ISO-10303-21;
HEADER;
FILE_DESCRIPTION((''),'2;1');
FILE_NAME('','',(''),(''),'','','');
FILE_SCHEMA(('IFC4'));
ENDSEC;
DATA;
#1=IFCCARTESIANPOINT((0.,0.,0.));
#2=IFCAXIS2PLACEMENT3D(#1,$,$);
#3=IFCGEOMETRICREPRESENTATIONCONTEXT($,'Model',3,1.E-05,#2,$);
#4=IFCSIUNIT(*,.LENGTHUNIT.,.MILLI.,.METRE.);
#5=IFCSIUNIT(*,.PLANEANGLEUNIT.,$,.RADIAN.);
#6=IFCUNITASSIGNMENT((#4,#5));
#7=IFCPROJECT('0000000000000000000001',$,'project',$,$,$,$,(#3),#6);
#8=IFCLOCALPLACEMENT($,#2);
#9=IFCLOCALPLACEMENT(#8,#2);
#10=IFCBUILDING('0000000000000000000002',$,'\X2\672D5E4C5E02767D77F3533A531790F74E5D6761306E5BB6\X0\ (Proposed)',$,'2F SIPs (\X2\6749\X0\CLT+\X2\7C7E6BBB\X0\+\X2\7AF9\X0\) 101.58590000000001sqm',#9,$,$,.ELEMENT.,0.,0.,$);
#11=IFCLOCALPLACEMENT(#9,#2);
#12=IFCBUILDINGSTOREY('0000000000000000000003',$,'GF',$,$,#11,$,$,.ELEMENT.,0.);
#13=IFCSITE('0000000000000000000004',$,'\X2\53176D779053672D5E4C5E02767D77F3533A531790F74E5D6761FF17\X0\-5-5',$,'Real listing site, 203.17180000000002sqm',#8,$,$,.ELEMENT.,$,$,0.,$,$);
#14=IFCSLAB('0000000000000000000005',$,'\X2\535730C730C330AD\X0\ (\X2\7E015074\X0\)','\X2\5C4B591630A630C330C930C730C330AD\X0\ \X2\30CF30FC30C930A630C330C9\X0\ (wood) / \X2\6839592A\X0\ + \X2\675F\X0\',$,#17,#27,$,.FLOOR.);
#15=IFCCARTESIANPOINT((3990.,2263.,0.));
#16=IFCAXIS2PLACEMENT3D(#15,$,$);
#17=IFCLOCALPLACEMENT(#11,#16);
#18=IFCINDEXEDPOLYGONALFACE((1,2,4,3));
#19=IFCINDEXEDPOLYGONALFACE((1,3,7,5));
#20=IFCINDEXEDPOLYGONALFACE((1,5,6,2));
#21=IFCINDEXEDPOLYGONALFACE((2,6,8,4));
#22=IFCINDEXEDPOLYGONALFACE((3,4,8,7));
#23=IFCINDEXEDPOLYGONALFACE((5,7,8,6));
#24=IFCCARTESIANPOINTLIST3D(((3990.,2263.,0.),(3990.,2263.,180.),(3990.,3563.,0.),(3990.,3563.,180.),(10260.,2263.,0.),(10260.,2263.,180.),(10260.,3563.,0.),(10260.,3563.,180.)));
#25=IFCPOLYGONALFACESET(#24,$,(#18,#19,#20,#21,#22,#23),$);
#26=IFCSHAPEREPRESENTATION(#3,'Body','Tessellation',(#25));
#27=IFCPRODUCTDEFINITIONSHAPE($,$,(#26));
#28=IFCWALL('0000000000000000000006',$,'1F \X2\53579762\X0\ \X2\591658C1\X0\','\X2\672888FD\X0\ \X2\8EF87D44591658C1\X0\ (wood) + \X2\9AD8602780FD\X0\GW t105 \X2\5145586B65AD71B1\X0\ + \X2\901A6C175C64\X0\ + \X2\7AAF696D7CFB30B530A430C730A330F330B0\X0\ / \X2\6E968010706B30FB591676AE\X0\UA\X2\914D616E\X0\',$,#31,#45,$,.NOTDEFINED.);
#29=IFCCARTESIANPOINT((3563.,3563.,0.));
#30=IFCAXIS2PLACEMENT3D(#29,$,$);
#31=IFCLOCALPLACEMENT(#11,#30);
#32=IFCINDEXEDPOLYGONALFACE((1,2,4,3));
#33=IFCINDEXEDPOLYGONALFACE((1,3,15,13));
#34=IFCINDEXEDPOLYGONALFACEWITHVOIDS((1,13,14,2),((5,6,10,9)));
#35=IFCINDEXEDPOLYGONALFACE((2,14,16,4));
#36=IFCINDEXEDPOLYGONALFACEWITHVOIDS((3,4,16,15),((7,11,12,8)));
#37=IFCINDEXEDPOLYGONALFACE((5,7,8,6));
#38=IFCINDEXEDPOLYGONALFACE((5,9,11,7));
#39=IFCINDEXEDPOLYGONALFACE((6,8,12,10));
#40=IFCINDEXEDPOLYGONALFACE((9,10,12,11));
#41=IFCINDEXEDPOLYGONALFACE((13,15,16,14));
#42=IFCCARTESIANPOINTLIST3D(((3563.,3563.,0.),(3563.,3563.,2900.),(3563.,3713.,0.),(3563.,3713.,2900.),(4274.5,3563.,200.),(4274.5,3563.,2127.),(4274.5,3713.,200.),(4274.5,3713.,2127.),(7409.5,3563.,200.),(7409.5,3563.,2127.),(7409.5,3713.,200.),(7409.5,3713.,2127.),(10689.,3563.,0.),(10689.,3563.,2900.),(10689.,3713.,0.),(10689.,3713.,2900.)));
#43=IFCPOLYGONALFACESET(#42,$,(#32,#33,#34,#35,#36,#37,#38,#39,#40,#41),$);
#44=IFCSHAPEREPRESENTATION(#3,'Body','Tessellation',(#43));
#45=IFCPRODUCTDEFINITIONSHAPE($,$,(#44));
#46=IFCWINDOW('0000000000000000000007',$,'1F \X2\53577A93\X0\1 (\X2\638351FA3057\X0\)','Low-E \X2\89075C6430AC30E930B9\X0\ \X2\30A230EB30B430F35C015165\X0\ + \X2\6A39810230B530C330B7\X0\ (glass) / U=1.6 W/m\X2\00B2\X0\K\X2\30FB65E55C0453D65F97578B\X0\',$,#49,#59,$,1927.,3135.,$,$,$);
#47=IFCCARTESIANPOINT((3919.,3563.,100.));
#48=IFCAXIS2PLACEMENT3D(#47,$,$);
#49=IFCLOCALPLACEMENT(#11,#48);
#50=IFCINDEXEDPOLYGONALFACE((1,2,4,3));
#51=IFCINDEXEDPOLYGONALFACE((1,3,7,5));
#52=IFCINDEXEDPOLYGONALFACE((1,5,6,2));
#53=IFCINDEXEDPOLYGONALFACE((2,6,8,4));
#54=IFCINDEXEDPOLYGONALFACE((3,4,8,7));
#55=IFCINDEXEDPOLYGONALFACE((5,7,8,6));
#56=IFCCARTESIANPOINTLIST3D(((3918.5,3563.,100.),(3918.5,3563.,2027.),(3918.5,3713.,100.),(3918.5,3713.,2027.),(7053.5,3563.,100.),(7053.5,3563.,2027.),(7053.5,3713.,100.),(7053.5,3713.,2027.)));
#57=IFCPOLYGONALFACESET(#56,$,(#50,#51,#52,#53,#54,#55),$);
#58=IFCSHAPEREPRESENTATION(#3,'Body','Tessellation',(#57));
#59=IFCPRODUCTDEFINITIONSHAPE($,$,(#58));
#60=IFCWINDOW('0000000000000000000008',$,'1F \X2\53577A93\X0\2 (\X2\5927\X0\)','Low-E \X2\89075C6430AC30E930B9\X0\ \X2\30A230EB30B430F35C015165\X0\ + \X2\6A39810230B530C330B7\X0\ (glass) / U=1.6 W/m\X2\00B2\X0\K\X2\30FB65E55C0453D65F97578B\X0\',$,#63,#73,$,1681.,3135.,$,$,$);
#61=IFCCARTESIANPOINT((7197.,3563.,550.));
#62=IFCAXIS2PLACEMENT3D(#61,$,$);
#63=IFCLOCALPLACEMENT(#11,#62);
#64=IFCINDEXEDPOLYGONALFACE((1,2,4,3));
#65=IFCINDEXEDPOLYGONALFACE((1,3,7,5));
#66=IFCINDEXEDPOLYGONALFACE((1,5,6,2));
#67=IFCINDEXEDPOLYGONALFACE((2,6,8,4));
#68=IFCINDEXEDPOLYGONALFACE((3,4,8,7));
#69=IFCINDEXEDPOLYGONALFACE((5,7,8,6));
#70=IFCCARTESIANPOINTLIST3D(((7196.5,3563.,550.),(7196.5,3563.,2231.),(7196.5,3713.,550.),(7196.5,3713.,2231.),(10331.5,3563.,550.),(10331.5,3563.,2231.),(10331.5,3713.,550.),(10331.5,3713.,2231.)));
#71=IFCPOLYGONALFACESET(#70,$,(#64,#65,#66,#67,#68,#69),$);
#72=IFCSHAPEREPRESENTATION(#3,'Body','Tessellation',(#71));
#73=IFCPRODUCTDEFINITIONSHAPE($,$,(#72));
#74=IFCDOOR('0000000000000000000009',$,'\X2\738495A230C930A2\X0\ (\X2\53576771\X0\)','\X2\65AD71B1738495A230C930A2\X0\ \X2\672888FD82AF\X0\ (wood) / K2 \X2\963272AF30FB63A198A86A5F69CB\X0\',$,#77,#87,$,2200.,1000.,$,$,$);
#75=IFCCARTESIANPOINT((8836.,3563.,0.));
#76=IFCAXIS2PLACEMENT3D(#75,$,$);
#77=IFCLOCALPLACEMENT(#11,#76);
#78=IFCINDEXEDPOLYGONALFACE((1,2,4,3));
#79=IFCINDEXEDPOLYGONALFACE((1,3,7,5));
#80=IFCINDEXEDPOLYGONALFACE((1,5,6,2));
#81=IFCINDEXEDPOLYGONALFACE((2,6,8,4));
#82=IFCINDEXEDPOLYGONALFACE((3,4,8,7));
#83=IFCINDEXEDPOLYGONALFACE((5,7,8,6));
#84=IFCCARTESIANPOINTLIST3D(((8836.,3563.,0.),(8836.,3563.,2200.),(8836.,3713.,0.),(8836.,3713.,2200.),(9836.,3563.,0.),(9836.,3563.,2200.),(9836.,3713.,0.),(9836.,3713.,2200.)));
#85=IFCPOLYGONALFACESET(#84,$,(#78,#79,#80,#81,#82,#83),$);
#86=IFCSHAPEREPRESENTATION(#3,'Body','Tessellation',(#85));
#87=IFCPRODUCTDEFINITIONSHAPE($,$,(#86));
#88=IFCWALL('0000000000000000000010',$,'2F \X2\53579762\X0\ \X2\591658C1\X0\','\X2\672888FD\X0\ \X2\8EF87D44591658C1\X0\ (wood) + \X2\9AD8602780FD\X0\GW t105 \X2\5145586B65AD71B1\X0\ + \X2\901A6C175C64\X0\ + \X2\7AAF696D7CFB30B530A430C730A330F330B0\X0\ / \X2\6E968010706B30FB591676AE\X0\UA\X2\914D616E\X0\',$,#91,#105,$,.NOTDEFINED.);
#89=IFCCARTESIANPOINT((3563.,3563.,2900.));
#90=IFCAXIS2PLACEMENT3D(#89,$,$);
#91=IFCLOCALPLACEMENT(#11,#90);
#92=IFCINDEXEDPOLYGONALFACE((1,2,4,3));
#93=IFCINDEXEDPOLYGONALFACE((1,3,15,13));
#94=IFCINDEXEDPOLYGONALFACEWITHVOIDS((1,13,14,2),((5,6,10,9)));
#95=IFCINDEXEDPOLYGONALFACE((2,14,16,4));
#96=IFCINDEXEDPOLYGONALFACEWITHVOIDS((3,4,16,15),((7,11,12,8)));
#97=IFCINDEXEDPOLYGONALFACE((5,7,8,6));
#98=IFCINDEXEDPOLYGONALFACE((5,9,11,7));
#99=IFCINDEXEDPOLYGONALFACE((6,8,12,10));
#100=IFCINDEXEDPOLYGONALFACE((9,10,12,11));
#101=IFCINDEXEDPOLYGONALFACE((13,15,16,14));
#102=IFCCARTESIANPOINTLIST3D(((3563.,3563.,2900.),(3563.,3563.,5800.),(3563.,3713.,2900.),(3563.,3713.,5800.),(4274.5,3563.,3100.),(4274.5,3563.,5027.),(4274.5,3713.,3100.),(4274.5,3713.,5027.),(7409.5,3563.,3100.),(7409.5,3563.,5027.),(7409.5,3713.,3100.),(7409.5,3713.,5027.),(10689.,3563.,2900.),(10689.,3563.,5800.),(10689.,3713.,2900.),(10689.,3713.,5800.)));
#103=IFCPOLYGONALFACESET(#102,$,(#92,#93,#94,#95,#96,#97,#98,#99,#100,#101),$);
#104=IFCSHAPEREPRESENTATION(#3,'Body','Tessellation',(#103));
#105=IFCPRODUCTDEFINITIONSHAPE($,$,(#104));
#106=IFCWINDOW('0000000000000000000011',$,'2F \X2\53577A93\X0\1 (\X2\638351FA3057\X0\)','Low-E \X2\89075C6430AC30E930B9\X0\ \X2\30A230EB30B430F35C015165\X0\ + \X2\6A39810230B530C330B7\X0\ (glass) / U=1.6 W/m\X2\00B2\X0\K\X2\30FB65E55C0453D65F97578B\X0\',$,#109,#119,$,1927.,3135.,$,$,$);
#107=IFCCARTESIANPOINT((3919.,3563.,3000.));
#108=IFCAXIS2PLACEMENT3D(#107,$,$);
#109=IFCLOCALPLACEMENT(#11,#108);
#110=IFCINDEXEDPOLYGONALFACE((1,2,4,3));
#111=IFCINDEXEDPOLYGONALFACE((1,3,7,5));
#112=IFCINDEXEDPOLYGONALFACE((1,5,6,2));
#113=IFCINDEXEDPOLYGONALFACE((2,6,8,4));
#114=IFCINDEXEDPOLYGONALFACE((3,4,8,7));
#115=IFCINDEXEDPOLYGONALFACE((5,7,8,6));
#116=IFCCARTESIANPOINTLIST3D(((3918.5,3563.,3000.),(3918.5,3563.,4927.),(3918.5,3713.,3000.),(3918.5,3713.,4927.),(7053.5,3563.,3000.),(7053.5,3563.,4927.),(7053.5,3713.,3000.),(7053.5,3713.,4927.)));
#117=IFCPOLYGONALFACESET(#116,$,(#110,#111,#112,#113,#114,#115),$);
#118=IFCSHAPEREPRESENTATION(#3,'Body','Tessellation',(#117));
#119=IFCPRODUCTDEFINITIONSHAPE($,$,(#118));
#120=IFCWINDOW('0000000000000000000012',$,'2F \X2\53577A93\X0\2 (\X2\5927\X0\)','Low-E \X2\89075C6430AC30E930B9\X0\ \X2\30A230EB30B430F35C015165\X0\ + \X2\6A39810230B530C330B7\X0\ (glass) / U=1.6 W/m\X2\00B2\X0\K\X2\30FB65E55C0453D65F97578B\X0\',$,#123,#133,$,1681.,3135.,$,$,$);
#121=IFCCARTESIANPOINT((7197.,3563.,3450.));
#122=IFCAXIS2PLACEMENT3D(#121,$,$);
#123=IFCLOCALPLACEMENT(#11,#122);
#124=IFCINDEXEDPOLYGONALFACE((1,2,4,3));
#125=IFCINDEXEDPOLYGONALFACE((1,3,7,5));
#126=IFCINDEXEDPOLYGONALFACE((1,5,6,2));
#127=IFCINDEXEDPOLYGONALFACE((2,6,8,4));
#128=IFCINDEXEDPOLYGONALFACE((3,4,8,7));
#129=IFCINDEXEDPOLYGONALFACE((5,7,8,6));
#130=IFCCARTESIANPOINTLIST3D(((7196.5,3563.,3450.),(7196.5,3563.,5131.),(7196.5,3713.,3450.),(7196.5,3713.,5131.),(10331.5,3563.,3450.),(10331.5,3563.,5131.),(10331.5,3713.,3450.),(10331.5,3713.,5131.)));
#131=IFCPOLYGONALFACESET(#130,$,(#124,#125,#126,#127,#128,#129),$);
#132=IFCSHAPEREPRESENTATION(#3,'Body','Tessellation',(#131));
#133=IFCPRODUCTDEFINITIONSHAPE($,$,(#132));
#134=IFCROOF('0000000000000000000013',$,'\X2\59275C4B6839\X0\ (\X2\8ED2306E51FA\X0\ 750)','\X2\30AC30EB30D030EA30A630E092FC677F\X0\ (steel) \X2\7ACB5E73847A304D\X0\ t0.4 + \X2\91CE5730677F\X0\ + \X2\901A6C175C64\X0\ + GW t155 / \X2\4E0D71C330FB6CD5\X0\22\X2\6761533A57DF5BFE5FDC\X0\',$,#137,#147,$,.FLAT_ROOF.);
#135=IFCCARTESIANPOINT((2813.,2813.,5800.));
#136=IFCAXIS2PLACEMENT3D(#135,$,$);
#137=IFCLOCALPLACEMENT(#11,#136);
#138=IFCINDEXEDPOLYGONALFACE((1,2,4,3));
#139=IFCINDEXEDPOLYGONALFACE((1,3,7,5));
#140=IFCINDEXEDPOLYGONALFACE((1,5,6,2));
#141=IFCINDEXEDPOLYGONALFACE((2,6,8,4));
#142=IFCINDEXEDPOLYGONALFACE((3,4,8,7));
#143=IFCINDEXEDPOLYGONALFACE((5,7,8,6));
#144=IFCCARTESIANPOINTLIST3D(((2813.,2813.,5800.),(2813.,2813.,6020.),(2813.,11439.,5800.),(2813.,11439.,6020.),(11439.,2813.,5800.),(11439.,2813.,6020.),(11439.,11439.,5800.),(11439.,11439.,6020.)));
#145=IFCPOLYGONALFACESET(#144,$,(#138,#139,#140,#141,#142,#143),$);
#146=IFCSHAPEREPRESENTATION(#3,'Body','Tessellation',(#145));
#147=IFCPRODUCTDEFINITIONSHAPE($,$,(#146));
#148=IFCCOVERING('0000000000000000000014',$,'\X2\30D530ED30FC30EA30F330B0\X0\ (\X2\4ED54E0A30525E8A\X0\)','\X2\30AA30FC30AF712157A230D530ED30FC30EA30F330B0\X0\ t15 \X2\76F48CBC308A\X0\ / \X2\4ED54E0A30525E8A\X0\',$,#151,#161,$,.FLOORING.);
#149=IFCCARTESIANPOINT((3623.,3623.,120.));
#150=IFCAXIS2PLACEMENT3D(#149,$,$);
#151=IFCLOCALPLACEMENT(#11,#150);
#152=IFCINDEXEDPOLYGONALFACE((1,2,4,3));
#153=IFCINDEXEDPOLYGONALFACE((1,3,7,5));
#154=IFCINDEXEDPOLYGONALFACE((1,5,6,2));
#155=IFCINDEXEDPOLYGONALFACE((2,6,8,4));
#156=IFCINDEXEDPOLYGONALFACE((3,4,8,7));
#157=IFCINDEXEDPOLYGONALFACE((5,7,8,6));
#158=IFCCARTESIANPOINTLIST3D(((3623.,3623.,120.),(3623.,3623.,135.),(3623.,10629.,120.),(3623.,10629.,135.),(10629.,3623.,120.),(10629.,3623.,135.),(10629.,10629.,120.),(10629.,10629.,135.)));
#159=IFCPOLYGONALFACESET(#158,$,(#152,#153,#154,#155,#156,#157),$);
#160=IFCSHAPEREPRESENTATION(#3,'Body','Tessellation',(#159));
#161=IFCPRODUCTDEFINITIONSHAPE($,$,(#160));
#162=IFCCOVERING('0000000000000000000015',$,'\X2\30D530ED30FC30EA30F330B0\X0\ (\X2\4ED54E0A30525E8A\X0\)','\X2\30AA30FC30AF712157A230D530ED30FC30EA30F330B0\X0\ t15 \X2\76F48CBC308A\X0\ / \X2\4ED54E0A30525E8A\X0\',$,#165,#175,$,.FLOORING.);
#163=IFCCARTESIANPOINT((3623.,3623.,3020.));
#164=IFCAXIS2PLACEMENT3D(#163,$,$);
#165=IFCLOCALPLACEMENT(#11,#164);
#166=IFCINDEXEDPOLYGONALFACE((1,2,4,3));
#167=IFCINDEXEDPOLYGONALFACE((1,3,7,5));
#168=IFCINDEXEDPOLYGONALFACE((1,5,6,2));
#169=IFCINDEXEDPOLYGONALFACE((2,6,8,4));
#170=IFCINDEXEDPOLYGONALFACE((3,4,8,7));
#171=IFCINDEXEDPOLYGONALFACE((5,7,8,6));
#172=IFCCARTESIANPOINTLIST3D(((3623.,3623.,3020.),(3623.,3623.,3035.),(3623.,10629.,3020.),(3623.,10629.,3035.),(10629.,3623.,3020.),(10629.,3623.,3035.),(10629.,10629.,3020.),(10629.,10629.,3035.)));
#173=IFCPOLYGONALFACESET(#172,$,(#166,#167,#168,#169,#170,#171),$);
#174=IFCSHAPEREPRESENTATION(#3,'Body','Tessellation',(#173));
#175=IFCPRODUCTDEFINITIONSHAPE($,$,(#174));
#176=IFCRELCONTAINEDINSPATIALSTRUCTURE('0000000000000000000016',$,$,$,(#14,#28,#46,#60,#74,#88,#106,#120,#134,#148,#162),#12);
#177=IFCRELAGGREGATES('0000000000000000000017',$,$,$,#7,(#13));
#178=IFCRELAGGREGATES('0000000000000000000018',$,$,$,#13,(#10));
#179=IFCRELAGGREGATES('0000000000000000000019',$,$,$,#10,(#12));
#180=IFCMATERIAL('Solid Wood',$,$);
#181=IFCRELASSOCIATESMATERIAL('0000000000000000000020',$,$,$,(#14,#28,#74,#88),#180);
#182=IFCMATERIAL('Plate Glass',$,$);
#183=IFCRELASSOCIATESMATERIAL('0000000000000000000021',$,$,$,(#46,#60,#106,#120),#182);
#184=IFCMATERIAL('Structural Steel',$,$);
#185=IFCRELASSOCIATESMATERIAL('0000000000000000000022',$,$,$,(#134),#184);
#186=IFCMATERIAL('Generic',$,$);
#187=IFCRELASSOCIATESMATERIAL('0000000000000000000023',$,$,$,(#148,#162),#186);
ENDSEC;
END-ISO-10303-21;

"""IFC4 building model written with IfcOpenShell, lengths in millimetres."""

from ifc_helpers import new_model, si_unit, frame, frame_2d, origin, place, context, project, spatial, rectangle, extrude, material, element, fill, save


model = new_model("IFC4")

# Units and contexts
model_context = context("Model", 3, precision=1e-05, world=origin())
ifc_project = project(units=[si_unit("LENGTHUNIT", "METRE", prefix="MILLI"), si_unit("PLANEANGLEUNIT", "RADIAN")], contexts=[model_context])

# Site, building, storey
site_placement = place(None, origin())
site = spatial("IfcSite", under=ifc_project, at=site_placement, Name="北海道札幌市白石区北郷九条７-5-5", ObjectType="Real listing site, 203.17180000000002sqm", CompositionType="ELEMENT", RefElevation=0.0)
building_placement = place(site_placement, origin())
building = spatial("IfcBuilding", under=site, at=building_placement, Name="札幌市白石区北郷九条の家 (Proposed)", ObjectType="2F SIPs (杉CLT+籾殻+竹) 101.58590000000001sqm", CompositionType="ELEMENT", ElevationOfRefHeight=0.0, ElevationOfTerrain=0.0)
storey_placement = place(building_placement, origin())
storey = spatial("IfcBuildingStorey", under=building, at=storey_placement, Name="GF", CompositionType="ELEMENT", Elevation=0.0)

# Slab
ifc_material_1 = material(Name="Solid Wood")
slab_1_placement = place(storey_placement, frame((3990.0, 2263.0, 0.0)))
element("IfcSlab", 1, at=slab_1_placement, inside=storey, material=ifc_material_1, Name="南デッキ (縁側)", Description="屋外ウッドデッキ ハードウッド (wood) / 根太 + 束", PredefinedType="FLOOR", context=model_context, shape_type="SweptSolid", body=[
    extrude(rectangle(XDim=6270.0, YDim=1300.0, at=frame_2d((3135.0, 650.0))), frame((3990.0, 2263.0, 0.0)), (0.0, 0.0, 1.0), 180.0),
])

# Wall, openings, windows, door
wall_1_placement = place(storey_placement, frame((3563.0, 3563.0, 0.0)))
wall_1 = element("IfcWall", 2, at=wall_1_placement, inside=storey, material=ifc_material_1, Name="1F 南面 外壁", Description="木製 軸組外壁 (wood) + 高性能GW t105 充填断熱 + 通気層 + 窯業系サイディング / 準耐火・外皮UA配慮", PredefinedType="NOTDEFINED", context=model_context, shape_type="SweptSolid", body=[
    extrude(rectangle(XDim=7126.0, YDim=150.0, at=frame_2d((3563.0, 75.0))), frame((3563.0, 3563.0, 0.0)), (0.0, 0.0, 1.0), 2900.0),
])
opening_1_placement = place(storey_placement, frame((3919.0, 3563.0, 100.0)))
opening_1 = element("IfcOpeningElement", 3, at=opening_1_placement, cuts=wall_1, PredefinedType="NOTDEFINED", context=model_context, shape_type="SweptSolid", body=[
    extrude(rectangle(XDim=3135.0, YDim=150.0, at=frame_2d((1567.0, 75.0))), frame((3919.0, 3563.0, 100.0)), (0.0, 0.0, 1.0), 1927.0),
])
opening_2_placement = place(storey_placement, frame((7197.0, 3563.0, 550.0)))
opening_2 = element("IfcOpeningElement", 4, at=opening_2_placement, cuts=wall_1, PredefinedType="NOTDEFINED", context=model_context, shape_type="SweptSolid", body=[
    extrude(rectangle(XDim=3135.0, YDim=150.0, at=frame_2d((1567.0, 75.0))), frame((7197.0, 3563.0, 550.0)), (0.0, 0.0, 1.0), 1681.0),
])
opening_3_placement = place(storey_placement, frame((8836.0, 3563.0, 0.0)))
opening_3 = element("IfcOpeningElement", 5, at=opening_3_placement, cuts=wall_1, PredefinedType="NOTDEFINED", context=model_context, shape_type="SweptSolid", body=[
    extrude(rectangle(XDim=1000.0, YDim=150.0, at=frame_2d((500.0, 75.0))), frame((8836.0, 3563.0, 0.0)), (0.0, 0.0, 1.0), 2200.0),
])
ifc_material_2 = material(Name="Plate Glass")
window_1_placement = place(storey_placement, frame((3919.0, 3563.0, 100.0)))
window_1 = element("IfcWindow", 6, at=window_1_placement, inside=storey, material=ifc_material_2, Name="1F 南窓1 (掃出し)", Description="Low-E 複層ガラス アルゴン封入 + 樹脂サッシ (glass) / U=1.6 W/m²K・日射取得型", OverallHeight=1927.0, OverallWidth=3135.0, context=model_context, shape_type="SweptSolid", body=[
    extrude(rectangle(XDim=3135.0, YDim=150.0, at=frame_2d((1567.0, 75.0))), frame((3919.0, 3563.0, 100.0)), (0.0, 0.0, 1.0), 1927.0),
])
fill(opening_1, window_1)
window_2_placement = place(storey_placement, frame((7197.0, 3563.0, 550.0)))
window_2 = element("IfcWindow", 7, at=window_2_placement, inside=storey, material=ifc_material_2, Name="1F 南窓2 (大)", Description="Low-E 複層ガラス アルゴン封入 + 樹脂サッシ (glass) / U=1.6 W/m²K・日射取得型", OverallHeight=1681.0, OverallWidth=3135.0, context=model_context, shape_type="SweptSolid", body=[
    extrude(rectangle(XDim=3135.0, YDim=150.0, at=frame_2d((1567.0, 75.0))), frame((7197.0, 3563.0, 550.0)), (0.0, 0.0, 1.0), 1681.0),
])
fill(opening_2, window_2)
door_placement = place(storey_placement, frame((8836.0, 3563.0, 0.0)))
door = element("IfcDoor", 8, at=door_placement, inside=storey, material=ifc_material_1, Name="玄関ドア (南東)", Description="断熱玄関ドア 木製芯 (wood) / K2 防犯・採風機構", OverallHeight=2200.0, OverallWidth=1000.0, context=model_context, shape_type="SweptSolid", body=[
    extrude(rectangle(XDim=1000.0, YDim=150.0, at=frame_2d((500.0, 75.0))), frame((8836.0, 3563.0, 0.0)), (0.0, 0.0, 1.0), 2200.0),
])
fill(opening_3, door)

# Wall, openings, windows
wall_2_placement = place(storey_placement, frame((3563.0, 3563.0, 2900.0)))
wall_2 = element("IfcWall", 9, at=wall_2_placement, inside=storey, material=ifc_material_1, Name="2F 南面 外壁", Description="木製 軸組外壁 (wood) + 高性能GW t105 充填断熱 + 通気層 + 窯業系サイディング / 準耐火・外皮UA配慮", PredefinedType="NOTDEFINED", context=model_context, shape_type="SweptSolid", body=[
    extrude(rectangle(XDim=7126.0, YDim=150.0, at=frame_2d((3563.0, 75.0))), frame((3563.0, 3563.0, 2900.0)), (0.0, 0.0, 1.0), 2900.0),
])
opening_4_placement = place(storey_placement, frame((3919.0, 3563.0, 3000.0)))
opening_4 = element("IfcOpeningElement", 10, at=opening_4_placement, cuts=wall_2, PredefinedType="NOTDEFINED", context=model_context, shape_type="SweptSolid", body=[
    extrude(rectangle(XDim=3135.0, YDim=150.0, at=frame_2d((1567.0, 75.0))), frame((3919.0, 3563.0, 3000.0)), (0.0, 0.0, 1.0), 1927.0),
])
opening_5_placement = place(storey_placement, frame((7197.0, 3563.0, 3450.0)))
opening_5 = element("IfcOpeningElement", 11, at=opening_5_placement, cuts=wall_2, PredefinedType="NOTDEFINED", context=model_context, shape_type="SweptSolid", body=[
    extrude(rectangle(XDim=3135.0, YDim=150.0, at=frame_2d((1567.0, 75.0))), frame((7197.0, 3563.0, 3450.0)), (0.0, 0.0, 1.0), 1681.0),
])
window_3_placement = place(storey_placement, frame((3919.0, 3563.0, 3000.0)))
window_3 = element("IfcWindow", 12, at=window_3_placement, inside=storey, material=ifc_material_2, Name="2F 南窓1 (掃出し)", Description="Low-E 複層ガラス アルゴン封入 + 樹脂サッシ (glass) / U=1.6 W/m²K・日射取得型", OverallHeight=1927.0, OverallWidth=3135.0, context=model_context, shape_type="SweptSolid", body=[
    extrude(rectangle(XDim=3135.0, YDim=150.0, at=frame_2d((1567.0, 75.0))), frame((3919.0, 3563.0, 3000.0)), (0.0, 0.0, 1.0), 1927.0),
])
fill(opening_4, window_3)
window_4_placement = place(storey_placement, frame((7197.0, 3563.0, 3450.0)))
window_4 = element("IfcWindow", 13, at=window_4_placement, inside=storey, material=ifc_material_2, Name="2F 南窓2 (大)", Description="Low-E 複層ガラス アルゴン封入 + 樹脂サッシ (glass) / U=1.6 W/m²K・日射取得型", OverallHeight=1681.0, OverallWidth=3135.0, context=model_context, shape_type="SweptSolid", body=[
    extrude(rectangle(XDim=3135.0, YDim=150.0, at=frame_2d((1567.0, 75.0))), frame((7197.0, 3563.0, 3450.0)), (0.0, 0.0, 1.0), 1681.0),
])
fill(opening_5, window_4)

# Roof
ifc_material_3 = material(Name="Structural Steel")
roof_placement = place(storey_placement, frame((2813.0, 2813.0, 5800.0)))
element("IfcRoof", 14, at=roof_placement, inside=storey, material=ifc_material_3, Name="大屋根 (軒の出 750)", Description="ガルバリウム鋼板 (steel) 立平葺き t0.4 + 野地板 + 通気層 + GW t155 / 不燃・法22条区域対応", PredefinedType="FLAT_ROOF", context=model_context, shape_type="SweptSolid", body=[
    extrude(rectangle(XDim=8626.0, YDim=8626.0, at=frame_2d((4313.0, 4313.0))), frame((2813.0, 2813.0, 5800.0)), (0.0, 0.0, 1.0), 220.0),
])

# Coverings
ifc_material_4 = material(Name="Generic")
covering_1_placement = place(storey_placement, frame((3623.0, 3623.0, 120.0)))
element("IfcCovering", 15, at=covering_1_placement, inside=storey, material=ifc_material_4, Name="フローリング (仕上げ床)", Description="オーク無垢フローリング t15 直貼り / 仕上げ床", PredefinedType="FLOORING", context=model_context, shape_type="SweptSolid", body=[
    extrude(rectangle(XDim=7006.0, YDim=7006.0, at=frame_2d((3503.0, 3503.0))), frame((3623.0, 3623.0, 120.0)), (0.0, 0.0, 1.0), 15.0),
])
covering_2_placement = place(storey_placement, frame((3623.0, 3623.0, 3020.0)))
element("IfcCovering", 16, at=covering_2_placement, inside=storey, material=ifc_material_4, Name="フローリング (仕上げ床)", Description="オーク無垢フローリング t15 直貼り / 仕上げ床", PredefinedType="FLOORING", context=model_context, shape_type="SweptSolid", body=[
    extrude(rectangle(XDim=7006.0, YDim=7006.0, at=frame_2d((3503.0, 3503.0))), frame((3623.0, 3623.0, 3020.0)), (0.0, 0.0, 1.0), 15.0),
])

save(model, "model.ifc")
